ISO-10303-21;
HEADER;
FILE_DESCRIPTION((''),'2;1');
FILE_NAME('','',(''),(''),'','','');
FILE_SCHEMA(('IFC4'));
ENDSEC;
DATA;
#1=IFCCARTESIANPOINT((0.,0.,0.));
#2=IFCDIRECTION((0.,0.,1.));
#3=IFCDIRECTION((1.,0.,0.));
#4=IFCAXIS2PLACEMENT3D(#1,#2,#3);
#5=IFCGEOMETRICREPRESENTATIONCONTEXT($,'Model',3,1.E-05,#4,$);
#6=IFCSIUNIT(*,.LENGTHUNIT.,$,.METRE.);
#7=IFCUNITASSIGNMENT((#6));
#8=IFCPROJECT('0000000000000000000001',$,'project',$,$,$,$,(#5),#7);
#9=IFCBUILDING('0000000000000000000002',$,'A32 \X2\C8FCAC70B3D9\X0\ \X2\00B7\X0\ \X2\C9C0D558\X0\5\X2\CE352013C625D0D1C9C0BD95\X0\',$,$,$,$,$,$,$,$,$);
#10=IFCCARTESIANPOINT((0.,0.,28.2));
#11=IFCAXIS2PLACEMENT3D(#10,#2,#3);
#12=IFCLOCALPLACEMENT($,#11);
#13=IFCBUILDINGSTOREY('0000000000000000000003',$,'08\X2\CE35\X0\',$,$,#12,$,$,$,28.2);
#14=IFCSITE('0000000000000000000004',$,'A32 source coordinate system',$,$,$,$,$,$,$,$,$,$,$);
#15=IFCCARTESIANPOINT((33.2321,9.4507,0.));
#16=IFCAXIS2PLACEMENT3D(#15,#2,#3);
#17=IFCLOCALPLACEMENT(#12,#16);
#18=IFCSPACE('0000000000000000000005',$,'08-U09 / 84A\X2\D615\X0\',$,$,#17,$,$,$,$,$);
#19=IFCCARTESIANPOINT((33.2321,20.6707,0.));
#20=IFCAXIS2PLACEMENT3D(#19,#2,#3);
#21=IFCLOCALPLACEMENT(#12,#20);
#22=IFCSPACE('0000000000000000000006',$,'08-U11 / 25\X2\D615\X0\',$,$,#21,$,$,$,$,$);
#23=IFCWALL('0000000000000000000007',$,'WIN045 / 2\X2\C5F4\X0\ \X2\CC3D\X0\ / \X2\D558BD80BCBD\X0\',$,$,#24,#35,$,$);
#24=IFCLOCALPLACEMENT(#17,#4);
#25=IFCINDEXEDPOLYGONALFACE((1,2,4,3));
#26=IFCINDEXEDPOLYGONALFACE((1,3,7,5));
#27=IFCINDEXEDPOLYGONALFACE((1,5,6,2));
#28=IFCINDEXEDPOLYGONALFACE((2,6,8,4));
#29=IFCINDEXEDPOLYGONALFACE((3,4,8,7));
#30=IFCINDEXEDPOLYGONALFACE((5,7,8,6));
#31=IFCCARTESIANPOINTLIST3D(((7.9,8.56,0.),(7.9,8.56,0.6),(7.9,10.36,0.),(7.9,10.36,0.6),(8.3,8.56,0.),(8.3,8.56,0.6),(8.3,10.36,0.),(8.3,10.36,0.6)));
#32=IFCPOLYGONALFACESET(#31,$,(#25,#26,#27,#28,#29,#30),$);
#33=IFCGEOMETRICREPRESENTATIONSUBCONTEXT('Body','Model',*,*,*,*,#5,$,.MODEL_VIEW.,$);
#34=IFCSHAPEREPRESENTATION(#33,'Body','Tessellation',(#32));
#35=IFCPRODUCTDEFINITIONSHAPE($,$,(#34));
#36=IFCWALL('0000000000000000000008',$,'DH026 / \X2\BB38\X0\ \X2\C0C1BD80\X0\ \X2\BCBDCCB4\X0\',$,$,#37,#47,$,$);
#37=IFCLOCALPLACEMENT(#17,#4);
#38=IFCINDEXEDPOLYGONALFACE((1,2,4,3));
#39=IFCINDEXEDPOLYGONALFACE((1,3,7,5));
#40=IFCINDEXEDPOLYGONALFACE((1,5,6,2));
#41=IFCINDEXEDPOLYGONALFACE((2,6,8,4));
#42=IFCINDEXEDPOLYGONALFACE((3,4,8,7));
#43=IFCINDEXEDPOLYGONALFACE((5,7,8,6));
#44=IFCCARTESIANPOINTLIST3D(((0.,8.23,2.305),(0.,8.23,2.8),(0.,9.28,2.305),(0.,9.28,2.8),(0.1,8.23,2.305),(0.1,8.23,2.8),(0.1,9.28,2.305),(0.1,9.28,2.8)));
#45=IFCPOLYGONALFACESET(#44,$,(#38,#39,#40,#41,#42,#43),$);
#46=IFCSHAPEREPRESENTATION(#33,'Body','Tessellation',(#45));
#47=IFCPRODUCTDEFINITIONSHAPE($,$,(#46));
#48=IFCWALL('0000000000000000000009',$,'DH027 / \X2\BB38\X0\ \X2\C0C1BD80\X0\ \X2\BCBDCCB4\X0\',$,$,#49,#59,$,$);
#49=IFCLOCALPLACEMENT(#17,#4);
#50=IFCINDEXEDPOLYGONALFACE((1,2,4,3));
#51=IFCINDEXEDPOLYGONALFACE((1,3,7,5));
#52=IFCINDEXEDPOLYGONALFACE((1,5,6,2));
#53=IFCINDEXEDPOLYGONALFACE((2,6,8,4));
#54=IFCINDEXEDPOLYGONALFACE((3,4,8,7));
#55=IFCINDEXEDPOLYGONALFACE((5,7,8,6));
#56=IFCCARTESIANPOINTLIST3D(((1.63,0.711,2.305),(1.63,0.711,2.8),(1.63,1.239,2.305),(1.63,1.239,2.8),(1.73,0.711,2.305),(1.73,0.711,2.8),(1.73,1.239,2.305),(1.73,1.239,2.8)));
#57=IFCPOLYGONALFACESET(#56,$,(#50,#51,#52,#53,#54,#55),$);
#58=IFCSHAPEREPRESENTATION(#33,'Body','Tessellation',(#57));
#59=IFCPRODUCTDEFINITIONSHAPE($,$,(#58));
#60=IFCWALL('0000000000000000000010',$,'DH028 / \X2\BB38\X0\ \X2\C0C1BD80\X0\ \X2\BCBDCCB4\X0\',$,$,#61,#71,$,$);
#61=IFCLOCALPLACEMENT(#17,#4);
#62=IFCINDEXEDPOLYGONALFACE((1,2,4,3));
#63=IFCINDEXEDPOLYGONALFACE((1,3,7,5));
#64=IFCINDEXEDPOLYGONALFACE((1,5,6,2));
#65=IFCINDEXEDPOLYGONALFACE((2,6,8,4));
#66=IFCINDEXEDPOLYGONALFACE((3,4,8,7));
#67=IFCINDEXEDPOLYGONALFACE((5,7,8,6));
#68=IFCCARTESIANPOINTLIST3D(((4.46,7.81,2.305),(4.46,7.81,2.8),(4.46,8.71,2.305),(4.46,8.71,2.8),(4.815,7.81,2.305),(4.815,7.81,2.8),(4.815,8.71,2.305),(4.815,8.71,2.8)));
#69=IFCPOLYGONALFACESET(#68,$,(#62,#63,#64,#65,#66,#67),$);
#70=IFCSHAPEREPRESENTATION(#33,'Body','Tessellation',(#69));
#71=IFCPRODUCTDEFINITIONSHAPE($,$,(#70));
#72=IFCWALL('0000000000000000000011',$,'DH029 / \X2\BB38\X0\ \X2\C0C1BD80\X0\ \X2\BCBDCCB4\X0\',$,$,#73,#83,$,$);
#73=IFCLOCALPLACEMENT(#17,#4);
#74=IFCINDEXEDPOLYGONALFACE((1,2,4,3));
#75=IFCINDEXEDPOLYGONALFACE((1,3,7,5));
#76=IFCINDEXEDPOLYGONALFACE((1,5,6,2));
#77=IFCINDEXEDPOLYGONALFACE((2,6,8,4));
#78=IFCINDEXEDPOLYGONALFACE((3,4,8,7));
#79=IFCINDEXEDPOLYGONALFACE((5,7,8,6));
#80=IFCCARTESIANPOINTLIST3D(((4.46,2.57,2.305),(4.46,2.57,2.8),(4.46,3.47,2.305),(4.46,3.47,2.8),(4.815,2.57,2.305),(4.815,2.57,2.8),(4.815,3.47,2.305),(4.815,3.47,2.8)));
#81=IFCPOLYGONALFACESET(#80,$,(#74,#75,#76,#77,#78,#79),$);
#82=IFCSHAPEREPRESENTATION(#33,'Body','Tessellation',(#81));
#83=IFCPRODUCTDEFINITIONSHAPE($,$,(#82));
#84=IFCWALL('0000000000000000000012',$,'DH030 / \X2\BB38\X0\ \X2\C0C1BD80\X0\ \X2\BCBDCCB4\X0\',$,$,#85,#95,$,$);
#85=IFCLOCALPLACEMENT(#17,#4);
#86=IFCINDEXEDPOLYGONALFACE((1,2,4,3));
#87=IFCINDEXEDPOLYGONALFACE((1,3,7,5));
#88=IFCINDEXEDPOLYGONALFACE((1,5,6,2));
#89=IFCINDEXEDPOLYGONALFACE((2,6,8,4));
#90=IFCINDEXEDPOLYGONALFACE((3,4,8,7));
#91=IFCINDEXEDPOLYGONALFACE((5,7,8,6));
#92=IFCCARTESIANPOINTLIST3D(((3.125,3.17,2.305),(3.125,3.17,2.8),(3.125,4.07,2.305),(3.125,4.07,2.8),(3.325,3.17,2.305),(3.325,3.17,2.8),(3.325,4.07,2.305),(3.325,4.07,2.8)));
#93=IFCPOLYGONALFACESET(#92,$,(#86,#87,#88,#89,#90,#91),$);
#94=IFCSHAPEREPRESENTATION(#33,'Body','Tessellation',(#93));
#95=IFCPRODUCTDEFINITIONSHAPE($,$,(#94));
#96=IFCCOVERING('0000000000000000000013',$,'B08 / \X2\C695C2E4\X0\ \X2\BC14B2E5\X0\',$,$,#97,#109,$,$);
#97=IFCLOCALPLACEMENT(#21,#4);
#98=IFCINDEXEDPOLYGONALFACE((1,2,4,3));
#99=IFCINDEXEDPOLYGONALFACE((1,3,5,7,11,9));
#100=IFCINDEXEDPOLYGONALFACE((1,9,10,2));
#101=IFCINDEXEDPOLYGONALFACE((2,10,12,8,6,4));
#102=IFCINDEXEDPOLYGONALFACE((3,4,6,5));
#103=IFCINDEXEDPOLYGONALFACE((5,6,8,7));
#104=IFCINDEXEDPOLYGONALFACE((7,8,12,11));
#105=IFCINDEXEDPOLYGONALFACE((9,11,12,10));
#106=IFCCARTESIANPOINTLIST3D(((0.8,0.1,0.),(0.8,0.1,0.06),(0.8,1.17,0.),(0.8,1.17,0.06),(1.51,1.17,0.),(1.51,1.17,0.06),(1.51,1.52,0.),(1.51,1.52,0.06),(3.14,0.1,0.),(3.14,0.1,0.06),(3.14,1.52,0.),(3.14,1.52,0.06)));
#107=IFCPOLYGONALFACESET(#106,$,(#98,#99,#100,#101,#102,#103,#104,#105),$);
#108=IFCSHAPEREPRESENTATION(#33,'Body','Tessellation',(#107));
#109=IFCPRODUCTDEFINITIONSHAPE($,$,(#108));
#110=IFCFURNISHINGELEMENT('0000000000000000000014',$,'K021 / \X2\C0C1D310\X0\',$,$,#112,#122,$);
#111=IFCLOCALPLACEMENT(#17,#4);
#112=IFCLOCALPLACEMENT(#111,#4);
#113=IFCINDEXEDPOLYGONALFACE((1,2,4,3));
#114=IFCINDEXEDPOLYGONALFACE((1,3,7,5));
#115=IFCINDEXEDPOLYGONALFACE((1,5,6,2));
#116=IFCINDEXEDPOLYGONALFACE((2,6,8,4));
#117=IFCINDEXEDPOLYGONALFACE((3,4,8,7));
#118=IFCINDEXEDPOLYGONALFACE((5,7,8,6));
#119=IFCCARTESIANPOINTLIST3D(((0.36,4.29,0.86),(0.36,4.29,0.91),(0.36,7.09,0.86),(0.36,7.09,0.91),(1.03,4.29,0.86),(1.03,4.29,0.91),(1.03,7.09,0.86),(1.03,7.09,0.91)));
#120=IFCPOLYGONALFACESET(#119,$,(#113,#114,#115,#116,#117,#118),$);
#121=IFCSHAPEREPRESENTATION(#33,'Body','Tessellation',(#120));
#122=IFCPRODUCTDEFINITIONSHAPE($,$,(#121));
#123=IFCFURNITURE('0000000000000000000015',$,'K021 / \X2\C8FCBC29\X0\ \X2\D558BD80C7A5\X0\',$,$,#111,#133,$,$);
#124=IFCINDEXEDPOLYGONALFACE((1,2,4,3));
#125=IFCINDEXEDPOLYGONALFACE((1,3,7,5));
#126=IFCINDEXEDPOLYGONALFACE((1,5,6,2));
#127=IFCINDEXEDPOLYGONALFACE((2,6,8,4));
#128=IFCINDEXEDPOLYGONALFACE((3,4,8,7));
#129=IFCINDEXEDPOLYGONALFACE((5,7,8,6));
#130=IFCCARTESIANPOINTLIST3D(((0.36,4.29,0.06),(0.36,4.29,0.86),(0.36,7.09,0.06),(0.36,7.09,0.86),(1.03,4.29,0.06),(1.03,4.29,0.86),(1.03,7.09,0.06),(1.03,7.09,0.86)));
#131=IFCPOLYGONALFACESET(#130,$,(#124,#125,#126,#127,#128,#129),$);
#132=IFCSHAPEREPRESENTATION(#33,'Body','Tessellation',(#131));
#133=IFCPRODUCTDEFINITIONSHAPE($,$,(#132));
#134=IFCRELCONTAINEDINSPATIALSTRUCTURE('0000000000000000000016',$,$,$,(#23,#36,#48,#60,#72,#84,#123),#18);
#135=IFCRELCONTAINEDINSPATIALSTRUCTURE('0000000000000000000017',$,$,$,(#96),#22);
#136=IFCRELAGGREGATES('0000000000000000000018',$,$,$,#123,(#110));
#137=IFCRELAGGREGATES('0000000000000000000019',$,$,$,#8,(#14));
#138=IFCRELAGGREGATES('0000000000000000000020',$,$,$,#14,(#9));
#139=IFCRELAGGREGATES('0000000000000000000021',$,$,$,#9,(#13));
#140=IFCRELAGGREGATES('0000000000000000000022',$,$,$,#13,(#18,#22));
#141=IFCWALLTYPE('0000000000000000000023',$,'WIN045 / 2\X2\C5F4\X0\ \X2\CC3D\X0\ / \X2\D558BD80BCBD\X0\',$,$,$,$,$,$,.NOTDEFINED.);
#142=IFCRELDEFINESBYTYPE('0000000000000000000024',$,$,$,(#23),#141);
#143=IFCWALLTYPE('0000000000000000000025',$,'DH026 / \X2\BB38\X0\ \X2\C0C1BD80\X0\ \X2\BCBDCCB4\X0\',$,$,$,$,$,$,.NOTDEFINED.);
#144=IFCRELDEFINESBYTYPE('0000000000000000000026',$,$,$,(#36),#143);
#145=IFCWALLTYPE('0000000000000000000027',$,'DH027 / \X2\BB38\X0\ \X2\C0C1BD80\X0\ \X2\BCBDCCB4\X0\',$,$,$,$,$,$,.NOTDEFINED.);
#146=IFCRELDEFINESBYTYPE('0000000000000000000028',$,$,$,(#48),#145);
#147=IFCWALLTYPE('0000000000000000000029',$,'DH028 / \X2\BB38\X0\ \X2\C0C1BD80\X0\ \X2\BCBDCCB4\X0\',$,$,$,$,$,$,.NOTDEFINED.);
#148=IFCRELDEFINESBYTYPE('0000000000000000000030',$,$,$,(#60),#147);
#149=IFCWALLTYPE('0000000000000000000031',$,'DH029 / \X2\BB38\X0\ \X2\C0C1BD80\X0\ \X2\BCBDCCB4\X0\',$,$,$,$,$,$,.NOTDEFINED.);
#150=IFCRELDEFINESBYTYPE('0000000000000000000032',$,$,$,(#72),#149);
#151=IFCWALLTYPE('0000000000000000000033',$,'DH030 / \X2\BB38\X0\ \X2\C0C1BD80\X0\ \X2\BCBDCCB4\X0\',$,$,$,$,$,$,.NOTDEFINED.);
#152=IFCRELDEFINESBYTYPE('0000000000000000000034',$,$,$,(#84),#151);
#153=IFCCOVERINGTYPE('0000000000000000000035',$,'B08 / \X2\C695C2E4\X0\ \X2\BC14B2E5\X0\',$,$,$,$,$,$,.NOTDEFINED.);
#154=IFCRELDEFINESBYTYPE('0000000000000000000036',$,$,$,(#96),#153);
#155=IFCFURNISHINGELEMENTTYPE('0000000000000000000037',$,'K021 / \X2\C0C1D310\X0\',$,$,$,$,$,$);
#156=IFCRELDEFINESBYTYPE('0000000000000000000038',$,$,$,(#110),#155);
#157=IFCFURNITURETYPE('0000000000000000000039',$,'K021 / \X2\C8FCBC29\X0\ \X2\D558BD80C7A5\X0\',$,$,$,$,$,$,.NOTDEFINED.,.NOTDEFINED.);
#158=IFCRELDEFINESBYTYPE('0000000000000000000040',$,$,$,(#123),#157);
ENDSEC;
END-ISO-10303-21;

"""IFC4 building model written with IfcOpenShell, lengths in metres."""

from ifc_helpers import new_model, si_unit, frame, origin, origin_with_axes, place, context, subcontext, project, spatial, polyline, outline, extrude, source, transform, mapped, type_object, type_shapes, element, aggregate, save


model = new_model("IFC4")

# Units and contexts
model_context = context("Model", 3, precision=1e-05, world=origin_with_axes())
body_context = subcontext(model_context, "Body", "Model", "MODEL_VIEW")
ifc_project = project(units=[si_unit("LENGTHUNIT", "METRE")], contexts=[model_context])

# Site, building, storey, space
site = spatial("IfcSite", under=ifc_project, Name="A32 source coordinate system")
building = spatial("IfcBuilding", under=site, Name="A32 주거동 · 지하5층–옥탑지붕")
storey_placement = place(None, frame((0.0, 0.0, 28.2), z_axis=(0.0, 0.0, 1.0), x_axis=(1.0, 0.0, 0.0)))
storey = spatial("IfcBuildingStorey", under=building, at=storey_placement, Name="08층", Elevation=28.2)
space_1_placement = place(storey_placement, frame((33.2321, 9.4507, 0.0), z_axis=(0.0, 0.0, 1.0), x_axis=(1.0, 0.0, 0.0)))
space_1 = spatial("IfcSpace", under=storey, at=space_1_placement, Name="08-U09 / 84A형")

# Walls
wall_type_1 = type_object("IfcWallType", Name="WIN045 / 2열 창 / 하부벽", PredefinedType="NOTDEFINED")
shared_shape_1 = source(origin(), body_context, "Body", "SweptSolid", [
    extrude(outline(polyline([(7.9, 10.36), (8.3, 10.36), (8.3, 8.56), (7.9, 8.56), (7.9, 10.36)])), origin(), (0.0, 0.0, 1.0), 0.6),
])
type_shapes(wall_type_1, [shared_shape_1])
wall_1_placement = place(space_1_placement, origin_with_axes())
element("IfcWall", 1, at=wall_1_placement, inside=space_1, type_object=wall_type_1, Name="WIN045 / 2열 창 / 하부벽", context=body_context, shape_type="MappedRepresentation", body=[
    mapped(shared_shape_1, transform((0.0, 0.0, 0.0), scale=1.0)),
])
wall_type_2 = type_object("IfcWallType", Name="DH026 / 문 상부 벽체", PredefinedType="NOTDEFINED")
shared_shape_2 = source(origin(), body_context, "Body", "SweptSolid", [
    extrude(outline(polyline([(0.1, 9.28), (0.1, 8.23), (0.0, 8.23), (0.0, 9.28), (0.1, 9.28)])), frame((0.0, 0.0, 2.305)), (0.0, 0.0, 1.0), 0.495),
])
type_shapes(wall_type_2, [shared_shape_2])
wall_2_placement = place(space_1_placement, origin_with_axes())
element("IfcWall", 2, at=wall_2_placement, inside=space_1, type_object=wall_type_2, Name="DH026 / 문 상부 벽체", context=body_context, shape_type="MappedRepresentation", body=[
    mapped(shared_shape_2, transform((0.0, 0.0, 0.0), scale=1.0)),
])
wall_type_3 = type_object("IfcWallType", Name="DH027 / 문 상부 벽체", PredefinedType="NOTDEFINED")
shared_shape_3 = source(origin(), body_context, "Body", "SweptSolid", [
    extrude(outline(polyline([(1.63, 1.239), (1.73, 1.239), (1.73, 0.711), (1.63, 0.711), (1.63, 1.239)])), frame((0.0, 0.0, 2.305)), (0.0, 0.0, 1.0), 0.495),
])
type_shapes(wall_type_3, [shared_shape_3])
wall_3_placement = place(space_1_placement, origin_with_axes())
element("IfcWall", 3, at=wall_3_placement, inside=space_1, type_object=wall_type_3, Name="DH027 / 문 상부 벽체", context=body_context, shape_type="MappedRepresentation", body=[
    mapped(shared_shape_3, transform((0.0, 0.0, 0.0), scale=1.0)),
])
wall_type_4 = type_object("IfcWallType", Name="DH028 / 문 상부 벽체", PredefinedType="NOTDEFINED")
shared_shape_4 = source(origin(), body_context, "Body", "SweptSolid", [
    extrude(outline(polyline([(4.815, 8.71), (4.815, 7.81), (4.46, 7.81), (4.46, 8.71), (4.815, 8.71)])), frame((0.0, 0.0, 2.305)), (0.0, 0.0, 1.0), 0.495),
])
type_shapes(wall_type_4, [shared_shape_4])
wall_4_placement = place(space_1_placement, origin_with_axes())
element("IfcWall", 4, at=wall_4_placement, inside=space_1, type_object=wall_type_4, Name="DH028 / 문 상부 벽체", context=body_context, shape_type="MappedRepresentation", body=[
    mapped(shared_shape_4, transform((0.0, 0.0, 0.0), scale=1.0)),
])
wall_type_5 = type_object("IfcWallType", Name="DH029 / 문 상부 벽체", PredefinedType="NOTDEFINED")
shared_shape_5 = source(origin(), body_context, "Body", "SweptSolid", [
    extrude(outline(polyline([(4.815, 3.47), (4.815, 2.57), (4.46, 2.57), (4.46, 3.47), (4.815, 3.47)])), frame((0.0, 0.0, 2.305)), (0.0, 0.0, 1.0), 0.495),
])
type_shapes(wall_type_5, [shared_shape_5])
wall_5_placement = place(space_1_placement, origin_with_axes())
element("IfcWall", 5, at=wall_5_placement, inside=space_1, type_object=wall_type_5, Name="DH029 / 문 상부 벽체", context=body_context, shape_type="MappedRepresentation", body=[
    mapped(shared_shape_5, transform((0.0, 0.0, 0.0), scale=1.0)),
])
wall_type_6 = type_object("IfcWallType", Name="DH030 / 문 상부 벽체", PredefinedType="NOTDEFINED")
shared_shape_6 = source(origin(), body_context, "Body", "SweptSolid", [
    extrude(outline(polyline([(3.325, 4.07), (3.325, 3.17), (3.125, 3.17), (3.125, 4.07), (3.325, 4.07)])), frame((0.0, 0.0, 2.305)), (0.0, 0.0, 1.0), 0.495),
])
type_shapes(wall_type_6, [shared_shape_6])
wall_6_placement = place(space_1_placement, origin_with_axes())
element("IfcWall", 6, at=wall_6_placement, inside=space_1, type_object=wall_type_6, Name="DH030 / 문 상부 벽체", context=body_context, shape_type="MappedRepresentation", body=[
    mapped(shared_shape_6, transform((0.0, 0.0, 0.0), scale=1.0)),
])

# Shared definitions
space_2_placement = place(storey_placement, frame((33.2321, 20.6707, 0.0), z_axis=(0.0, 0.0, 1.0), x_axis=(1.0, 0.0, 0.0)))
space_2 = spatial("IfcSpace", under=storey, at=space_2_placement, Name="08-U11 / 25형")

# Covering
covering_type_1 = type_object("IfcCoveringType", Name="B08 / 욕실 바닥", PredefinedType="NOTDEFINED")
shared_shape_7 = source(origin(), body_context, "Body", "SweptSolid", [
    extrude(outline(polyline([(3.14, 0.1), (0.8, 0.1), (0.8, 1.17), (1.51, 1.17), (1.51, 1.52), (3.14, 1.52), (3.14, 0.1)])), origin(), (0.0, 0.0, 1.0), 0.06),
])
type_shapes(covering_type_1, [shared_shape_7])
covering_1_placement = place(space_2_placement, origin_with_axes())
element("IfcCovering", 7, at=covering_1_placement, inside=space_2, type_object=covering_type_1, Name="B08 / 욕실 바닥", context=body_context, shape_type="MappedRepresentation", body=[
    mapped(shared_shape_7, transform((0.0, 0.0, 0.0), scale=1.0)),
])

# Furnishing element
furnishing_element_type = type_object("IfcFurnishingElementType", Name="K021 / 상판")
shared_shape_8 = source(origin(), body_context, "Body", "SweptSolid", [
    extrude(outline(polyline([(0.36, 7.09), (1.03, 7.09), (1.03, 4.29), (0.36, 4.29), (0.36, 7.09)])), frame((0.0, 0.0, 0.86)), (0.0, 0.0, 1.0), 0.05),
])
type_shapes(furnishing_element_type, [shared_shape_8])
furniture_placement = place(space_1_placement, origin_with_axes())
furnishing_placement = place(furniture_placement, origin_with_axes())
furnishing = element("IfcFurnishingElement", 8, at=furnishing_placement, type_object=furnishing_element_type, Name="K021 / 상판", context=body_context, shape_type="MappedRepresentation", body=[
    mapped(shared_shape_8, transform((0.0, 0.0, 0.0), scale=1.0)),
])

# Furniture
furniture_type = type_object("IfcFurnitureType", Name="K021 / 주방 하부장", AssemblyPlace="NOTDEFINED", PredefinedType="NOTDEFINED")
shared_shape_9 = source(origin(), body_context, "Body", "SweptSolid", [
    extrude(outline(polyline([(0.36, 4.29), (0.36, 7.09), (1.03, 7.09), (1.03, 4.29), (0.36, 4.29)])), frame((0.0, 0.0, 0.06)), (0.0, 0.0, 1.0), 0.8),
])
type_shapes(furniture_type, [shared_shape_9])
furniture = element("IfcFurniture", 9, at=furniture_placement, inside=space_1, type_object=furniture_type, Name="K021 / 주방 하부장", context=body_context, shape_type="MappedRepresentation", body=[
    mapped(shared_shape_9, transform((0.0, 0.0, 0.0), scale=1.0)),
])
aggregate(furniture, [furnishing])

save(model, "model.ifc")
